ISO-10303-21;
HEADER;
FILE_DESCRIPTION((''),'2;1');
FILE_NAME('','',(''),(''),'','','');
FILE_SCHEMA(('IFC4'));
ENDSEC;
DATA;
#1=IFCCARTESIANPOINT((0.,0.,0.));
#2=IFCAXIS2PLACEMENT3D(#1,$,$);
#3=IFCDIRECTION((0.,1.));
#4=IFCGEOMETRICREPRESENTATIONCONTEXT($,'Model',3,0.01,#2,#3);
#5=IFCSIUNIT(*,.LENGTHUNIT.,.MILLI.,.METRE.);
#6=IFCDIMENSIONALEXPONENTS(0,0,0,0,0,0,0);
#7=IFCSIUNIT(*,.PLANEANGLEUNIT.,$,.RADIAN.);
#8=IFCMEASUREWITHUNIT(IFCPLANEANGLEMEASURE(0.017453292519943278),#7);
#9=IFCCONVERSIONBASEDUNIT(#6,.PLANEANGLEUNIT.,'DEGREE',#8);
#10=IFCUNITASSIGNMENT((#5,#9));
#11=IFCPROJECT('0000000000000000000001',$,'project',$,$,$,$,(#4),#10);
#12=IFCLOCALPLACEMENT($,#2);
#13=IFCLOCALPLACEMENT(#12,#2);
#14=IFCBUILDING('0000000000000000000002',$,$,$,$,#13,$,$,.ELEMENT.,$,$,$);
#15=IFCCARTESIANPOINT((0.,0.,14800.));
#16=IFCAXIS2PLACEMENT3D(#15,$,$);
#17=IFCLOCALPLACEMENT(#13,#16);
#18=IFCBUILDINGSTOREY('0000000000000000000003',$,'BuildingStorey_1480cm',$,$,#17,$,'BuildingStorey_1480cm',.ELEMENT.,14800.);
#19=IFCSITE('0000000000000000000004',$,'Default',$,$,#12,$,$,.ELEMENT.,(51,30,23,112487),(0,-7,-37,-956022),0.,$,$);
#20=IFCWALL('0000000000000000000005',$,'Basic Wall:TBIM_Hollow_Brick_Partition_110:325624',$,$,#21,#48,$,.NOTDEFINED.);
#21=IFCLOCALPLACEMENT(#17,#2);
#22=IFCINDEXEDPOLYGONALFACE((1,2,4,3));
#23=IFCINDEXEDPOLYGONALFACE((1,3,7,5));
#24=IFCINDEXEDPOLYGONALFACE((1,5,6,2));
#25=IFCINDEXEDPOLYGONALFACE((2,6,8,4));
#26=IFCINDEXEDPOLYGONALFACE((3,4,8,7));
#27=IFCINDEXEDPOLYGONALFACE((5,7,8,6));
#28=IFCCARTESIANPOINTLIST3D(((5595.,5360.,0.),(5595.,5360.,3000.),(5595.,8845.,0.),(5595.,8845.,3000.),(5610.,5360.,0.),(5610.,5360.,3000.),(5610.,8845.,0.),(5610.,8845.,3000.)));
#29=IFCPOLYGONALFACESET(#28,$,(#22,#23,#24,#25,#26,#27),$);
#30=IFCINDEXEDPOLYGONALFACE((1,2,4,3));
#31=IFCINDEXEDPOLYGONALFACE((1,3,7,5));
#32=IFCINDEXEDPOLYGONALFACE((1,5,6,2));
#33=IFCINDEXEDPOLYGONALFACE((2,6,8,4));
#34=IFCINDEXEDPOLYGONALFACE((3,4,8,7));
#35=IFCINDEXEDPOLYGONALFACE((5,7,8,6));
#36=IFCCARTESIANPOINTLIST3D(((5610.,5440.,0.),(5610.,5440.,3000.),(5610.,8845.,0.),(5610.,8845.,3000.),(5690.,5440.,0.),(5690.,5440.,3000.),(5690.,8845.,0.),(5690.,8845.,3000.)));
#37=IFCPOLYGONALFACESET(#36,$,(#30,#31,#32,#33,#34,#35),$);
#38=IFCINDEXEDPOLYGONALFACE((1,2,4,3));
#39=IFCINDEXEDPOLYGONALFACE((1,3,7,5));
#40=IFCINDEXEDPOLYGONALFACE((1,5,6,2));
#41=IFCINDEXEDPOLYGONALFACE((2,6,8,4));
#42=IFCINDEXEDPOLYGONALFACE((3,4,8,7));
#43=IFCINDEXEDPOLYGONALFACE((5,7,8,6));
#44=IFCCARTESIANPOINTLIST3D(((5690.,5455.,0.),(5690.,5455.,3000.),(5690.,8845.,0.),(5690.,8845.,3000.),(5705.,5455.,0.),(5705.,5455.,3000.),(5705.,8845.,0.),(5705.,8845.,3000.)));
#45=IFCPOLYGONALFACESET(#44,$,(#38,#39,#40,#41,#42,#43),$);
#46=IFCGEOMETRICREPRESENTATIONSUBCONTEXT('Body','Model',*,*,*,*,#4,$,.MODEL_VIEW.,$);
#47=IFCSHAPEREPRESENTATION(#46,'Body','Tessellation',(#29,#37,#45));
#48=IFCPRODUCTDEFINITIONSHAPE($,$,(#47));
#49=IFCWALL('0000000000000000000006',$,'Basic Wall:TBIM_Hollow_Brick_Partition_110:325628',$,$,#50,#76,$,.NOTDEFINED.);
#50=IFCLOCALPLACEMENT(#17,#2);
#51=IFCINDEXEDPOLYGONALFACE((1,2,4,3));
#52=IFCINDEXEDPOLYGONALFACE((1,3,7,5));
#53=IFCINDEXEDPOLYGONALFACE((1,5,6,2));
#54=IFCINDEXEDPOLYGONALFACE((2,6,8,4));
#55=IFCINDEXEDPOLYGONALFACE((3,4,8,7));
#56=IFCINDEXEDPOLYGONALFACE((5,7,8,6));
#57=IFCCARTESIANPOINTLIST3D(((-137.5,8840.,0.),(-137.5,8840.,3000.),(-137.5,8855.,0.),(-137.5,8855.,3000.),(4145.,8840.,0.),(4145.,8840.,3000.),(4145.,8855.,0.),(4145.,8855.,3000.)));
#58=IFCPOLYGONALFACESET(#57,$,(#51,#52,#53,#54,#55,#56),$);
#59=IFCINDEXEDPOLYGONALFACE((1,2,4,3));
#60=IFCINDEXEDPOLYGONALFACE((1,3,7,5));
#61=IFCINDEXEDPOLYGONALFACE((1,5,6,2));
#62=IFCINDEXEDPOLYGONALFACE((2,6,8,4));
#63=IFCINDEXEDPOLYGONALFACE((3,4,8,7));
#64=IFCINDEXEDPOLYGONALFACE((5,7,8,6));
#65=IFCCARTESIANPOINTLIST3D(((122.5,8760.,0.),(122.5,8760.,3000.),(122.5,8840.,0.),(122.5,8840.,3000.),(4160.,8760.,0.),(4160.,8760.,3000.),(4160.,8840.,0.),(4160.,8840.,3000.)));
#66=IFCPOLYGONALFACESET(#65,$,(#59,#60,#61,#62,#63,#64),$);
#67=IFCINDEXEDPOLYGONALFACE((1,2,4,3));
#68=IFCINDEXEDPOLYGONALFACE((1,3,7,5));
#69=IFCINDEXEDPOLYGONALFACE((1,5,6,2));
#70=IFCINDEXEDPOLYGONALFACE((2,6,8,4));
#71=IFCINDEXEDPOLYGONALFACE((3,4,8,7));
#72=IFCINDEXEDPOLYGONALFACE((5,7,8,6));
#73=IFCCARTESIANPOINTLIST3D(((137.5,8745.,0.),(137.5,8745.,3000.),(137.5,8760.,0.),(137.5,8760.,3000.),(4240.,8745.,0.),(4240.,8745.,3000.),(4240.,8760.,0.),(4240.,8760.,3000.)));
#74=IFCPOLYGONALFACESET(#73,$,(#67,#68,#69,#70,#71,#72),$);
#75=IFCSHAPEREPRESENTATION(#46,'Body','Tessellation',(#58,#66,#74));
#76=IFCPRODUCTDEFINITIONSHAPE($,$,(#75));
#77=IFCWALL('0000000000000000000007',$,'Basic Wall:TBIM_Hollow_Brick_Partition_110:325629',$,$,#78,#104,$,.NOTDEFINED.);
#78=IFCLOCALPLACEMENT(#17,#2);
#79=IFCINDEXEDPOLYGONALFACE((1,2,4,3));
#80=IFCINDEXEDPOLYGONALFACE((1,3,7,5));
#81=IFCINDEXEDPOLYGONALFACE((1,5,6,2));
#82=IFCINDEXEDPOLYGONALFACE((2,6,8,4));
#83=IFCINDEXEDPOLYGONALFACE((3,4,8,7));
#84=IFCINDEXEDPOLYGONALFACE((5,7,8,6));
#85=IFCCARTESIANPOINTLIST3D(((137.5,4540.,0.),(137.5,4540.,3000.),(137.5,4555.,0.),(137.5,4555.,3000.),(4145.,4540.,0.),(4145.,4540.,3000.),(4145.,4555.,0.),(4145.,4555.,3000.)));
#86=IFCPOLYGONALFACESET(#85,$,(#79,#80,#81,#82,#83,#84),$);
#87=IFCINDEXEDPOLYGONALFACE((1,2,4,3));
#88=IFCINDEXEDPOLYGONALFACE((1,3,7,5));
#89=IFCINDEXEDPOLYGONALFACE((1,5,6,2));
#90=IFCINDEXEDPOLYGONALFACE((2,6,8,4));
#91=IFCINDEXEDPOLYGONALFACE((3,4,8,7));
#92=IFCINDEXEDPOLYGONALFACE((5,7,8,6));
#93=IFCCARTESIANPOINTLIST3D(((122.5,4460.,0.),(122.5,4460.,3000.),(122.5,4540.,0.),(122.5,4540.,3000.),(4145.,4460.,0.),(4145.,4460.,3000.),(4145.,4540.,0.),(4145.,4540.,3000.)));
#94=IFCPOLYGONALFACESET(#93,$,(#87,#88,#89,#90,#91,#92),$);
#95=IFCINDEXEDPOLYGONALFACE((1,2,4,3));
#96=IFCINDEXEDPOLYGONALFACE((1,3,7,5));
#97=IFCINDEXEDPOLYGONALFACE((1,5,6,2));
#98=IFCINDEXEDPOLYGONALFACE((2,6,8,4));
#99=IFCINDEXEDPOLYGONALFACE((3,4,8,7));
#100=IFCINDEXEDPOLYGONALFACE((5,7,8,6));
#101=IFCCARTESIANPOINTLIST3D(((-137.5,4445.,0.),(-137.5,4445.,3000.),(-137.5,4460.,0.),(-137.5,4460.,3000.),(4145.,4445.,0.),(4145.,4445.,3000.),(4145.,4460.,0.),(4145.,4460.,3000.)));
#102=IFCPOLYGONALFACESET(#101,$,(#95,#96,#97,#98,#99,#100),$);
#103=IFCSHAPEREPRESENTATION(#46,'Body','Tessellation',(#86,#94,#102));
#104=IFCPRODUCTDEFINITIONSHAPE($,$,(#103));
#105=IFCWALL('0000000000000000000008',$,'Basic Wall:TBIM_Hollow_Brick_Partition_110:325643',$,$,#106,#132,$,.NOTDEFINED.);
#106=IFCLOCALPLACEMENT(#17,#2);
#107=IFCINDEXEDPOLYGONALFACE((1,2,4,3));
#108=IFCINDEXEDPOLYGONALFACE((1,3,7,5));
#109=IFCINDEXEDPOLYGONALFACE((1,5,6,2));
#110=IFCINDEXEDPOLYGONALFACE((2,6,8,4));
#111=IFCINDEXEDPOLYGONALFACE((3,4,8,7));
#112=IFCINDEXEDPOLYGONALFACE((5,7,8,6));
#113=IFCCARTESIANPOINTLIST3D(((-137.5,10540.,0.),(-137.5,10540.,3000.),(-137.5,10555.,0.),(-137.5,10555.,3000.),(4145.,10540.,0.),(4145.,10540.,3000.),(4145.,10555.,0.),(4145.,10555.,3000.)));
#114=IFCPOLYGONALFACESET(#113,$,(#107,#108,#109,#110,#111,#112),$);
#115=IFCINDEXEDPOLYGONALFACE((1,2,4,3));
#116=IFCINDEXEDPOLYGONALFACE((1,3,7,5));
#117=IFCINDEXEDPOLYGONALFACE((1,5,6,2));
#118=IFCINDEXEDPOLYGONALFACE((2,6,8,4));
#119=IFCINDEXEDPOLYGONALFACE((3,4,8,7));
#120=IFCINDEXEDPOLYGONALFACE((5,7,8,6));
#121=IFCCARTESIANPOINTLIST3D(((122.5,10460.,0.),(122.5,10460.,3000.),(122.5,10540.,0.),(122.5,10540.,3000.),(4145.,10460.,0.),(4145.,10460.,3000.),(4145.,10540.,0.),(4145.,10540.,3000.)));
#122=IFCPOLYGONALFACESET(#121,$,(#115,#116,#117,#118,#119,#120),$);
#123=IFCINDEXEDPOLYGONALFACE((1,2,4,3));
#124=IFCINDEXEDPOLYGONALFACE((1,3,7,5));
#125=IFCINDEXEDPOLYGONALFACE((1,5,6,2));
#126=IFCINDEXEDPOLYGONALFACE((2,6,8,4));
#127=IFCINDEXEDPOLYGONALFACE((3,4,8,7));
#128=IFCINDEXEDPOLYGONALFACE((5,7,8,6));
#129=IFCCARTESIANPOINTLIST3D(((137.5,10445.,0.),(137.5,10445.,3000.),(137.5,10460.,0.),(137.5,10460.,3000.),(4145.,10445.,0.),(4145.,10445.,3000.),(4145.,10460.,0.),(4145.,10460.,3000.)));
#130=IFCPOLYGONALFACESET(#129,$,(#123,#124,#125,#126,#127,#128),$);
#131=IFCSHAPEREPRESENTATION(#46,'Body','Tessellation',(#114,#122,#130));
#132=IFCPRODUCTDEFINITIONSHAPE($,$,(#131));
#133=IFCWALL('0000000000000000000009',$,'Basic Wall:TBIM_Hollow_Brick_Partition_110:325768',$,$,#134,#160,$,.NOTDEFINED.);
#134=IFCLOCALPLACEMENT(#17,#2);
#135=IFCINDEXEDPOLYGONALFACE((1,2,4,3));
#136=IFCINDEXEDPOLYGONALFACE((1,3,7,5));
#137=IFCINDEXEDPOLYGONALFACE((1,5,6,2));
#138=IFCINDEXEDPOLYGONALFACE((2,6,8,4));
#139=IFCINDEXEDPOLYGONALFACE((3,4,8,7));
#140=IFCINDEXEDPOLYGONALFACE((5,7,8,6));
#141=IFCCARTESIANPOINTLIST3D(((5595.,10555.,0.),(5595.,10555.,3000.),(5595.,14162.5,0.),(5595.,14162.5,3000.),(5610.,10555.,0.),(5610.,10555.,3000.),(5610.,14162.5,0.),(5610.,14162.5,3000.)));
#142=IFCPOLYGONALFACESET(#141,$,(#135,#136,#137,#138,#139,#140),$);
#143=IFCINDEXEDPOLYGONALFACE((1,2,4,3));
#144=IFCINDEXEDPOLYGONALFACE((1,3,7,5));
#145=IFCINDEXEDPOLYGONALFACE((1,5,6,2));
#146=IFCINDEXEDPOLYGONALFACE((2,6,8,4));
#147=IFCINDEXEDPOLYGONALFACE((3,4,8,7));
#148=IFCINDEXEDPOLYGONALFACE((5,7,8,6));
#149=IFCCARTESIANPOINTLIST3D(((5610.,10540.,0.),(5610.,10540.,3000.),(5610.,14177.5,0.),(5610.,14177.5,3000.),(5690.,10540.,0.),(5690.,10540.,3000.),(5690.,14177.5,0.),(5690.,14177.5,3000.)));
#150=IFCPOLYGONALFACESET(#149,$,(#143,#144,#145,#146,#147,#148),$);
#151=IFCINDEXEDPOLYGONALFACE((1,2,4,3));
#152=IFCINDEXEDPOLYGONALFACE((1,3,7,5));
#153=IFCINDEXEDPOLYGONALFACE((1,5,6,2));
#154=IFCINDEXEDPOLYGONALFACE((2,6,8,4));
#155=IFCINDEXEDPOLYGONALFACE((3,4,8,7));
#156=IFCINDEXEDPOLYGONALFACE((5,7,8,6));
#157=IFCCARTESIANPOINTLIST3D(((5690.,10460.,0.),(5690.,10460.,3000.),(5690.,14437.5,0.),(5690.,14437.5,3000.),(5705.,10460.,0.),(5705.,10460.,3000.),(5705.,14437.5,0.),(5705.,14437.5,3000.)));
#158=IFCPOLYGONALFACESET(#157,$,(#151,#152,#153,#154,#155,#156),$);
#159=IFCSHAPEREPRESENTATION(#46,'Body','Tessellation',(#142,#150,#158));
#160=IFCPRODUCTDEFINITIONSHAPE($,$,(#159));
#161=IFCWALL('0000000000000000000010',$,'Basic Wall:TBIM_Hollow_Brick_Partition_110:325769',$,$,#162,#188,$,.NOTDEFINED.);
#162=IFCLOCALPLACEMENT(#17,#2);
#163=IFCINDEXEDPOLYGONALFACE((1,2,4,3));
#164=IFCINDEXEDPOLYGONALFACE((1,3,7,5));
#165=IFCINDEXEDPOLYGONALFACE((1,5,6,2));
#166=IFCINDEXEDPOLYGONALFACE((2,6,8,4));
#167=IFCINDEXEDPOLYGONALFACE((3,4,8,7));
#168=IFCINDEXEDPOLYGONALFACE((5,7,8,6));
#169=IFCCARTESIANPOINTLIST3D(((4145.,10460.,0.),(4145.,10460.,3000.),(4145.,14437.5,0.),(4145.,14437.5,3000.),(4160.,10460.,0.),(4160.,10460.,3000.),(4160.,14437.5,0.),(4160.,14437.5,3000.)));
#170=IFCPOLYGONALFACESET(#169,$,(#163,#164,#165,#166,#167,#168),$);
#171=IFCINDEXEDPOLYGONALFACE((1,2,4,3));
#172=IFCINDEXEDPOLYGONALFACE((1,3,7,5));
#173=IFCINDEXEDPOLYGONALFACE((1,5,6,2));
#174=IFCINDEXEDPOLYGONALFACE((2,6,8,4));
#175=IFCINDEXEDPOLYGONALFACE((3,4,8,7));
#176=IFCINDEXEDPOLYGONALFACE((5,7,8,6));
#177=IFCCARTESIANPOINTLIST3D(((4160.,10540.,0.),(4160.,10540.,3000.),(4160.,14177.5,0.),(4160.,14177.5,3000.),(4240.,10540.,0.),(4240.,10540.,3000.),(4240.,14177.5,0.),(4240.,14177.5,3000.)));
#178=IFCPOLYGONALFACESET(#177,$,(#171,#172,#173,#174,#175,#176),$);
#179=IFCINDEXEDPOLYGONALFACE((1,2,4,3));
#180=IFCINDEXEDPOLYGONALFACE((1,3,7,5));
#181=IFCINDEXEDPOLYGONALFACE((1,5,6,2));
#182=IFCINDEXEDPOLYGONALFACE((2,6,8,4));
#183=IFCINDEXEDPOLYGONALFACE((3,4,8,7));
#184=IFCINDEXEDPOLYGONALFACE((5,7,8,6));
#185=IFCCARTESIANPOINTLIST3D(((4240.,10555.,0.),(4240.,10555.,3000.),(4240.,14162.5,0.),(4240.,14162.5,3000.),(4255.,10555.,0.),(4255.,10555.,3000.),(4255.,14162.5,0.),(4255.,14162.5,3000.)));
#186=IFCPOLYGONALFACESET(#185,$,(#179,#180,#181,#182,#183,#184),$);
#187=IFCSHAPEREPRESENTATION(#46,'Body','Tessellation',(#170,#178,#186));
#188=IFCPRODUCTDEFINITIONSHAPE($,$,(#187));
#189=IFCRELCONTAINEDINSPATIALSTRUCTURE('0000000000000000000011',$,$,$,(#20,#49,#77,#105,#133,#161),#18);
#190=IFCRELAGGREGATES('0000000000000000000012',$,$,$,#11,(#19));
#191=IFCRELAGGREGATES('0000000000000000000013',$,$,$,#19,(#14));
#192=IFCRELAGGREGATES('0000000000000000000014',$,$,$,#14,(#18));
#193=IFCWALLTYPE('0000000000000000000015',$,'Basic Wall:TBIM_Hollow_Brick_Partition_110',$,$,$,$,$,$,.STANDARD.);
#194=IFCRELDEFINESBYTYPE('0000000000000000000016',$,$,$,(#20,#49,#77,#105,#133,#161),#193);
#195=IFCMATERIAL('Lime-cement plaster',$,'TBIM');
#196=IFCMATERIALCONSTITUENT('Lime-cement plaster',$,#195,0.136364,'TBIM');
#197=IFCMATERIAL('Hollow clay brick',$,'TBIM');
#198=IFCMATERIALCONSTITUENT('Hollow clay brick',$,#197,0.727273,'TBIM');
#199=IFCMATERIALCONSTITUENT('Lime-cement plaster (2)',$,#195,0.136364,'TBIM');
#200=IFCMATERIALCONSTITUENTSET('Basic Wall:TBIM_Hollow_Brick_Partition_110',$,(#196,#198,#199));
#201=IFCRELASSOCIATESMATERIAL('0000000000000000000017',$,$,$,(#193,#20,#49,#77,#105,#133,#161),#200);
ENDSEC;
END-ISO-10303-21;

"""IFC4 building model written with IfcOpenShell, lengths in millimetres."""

from ifc_helpers import new_model, entity, si_unit, converted_unit, direction, frame, origin, place, context, subcontext, project, spatial, indexed_curve, outline, extrude, material, constituent, constituent_set, type_object, element, save


model = new_model("IFC4")

# Units and contexts
model_context = context("Model", 3, precision=0.01, world=origin(), true_north=direction((0.0, 1.0)))
body_context = subcontext(model_context, "Body", "Model", "MODEL_VIEW")
ifc_project = project(units=[si_unit("LENGTHUNIT", "METRE", prefix="MILLI"), converted_unit("PLANEANGLEUNIT", "DEGREE", entity("IfcPlaneAngleMeasure", 0.017453292519943278), si_unit("PLANEANGLEUNIT", "RADIAN"), dimensions=[0, 0, 0, 0, 0, 0, 0])], contexts=[model_context])

# Site, building, storey
site_placement = place(None, origin())
site = spatial("IfcSite", under=ifc_project, at=site_placement, Name="Default", CompositionType="ELEMENT", RefLatitude=(51, 30, 23, 112487), RefLongitude=(0, -7, -37, -956022), RefElevation=0.0)
building_placement = place(site_placement, origin())
building = spatial("IfcBuilding", under=site, at=building_placement, CompositionType="ELEMENT")
storey_placement = place(building_placement, frame((0.0, 0.0, 14800.0)))
storey = spatial("IfcBuildingStorey", under=building, at=storey_placement, Name="BuildingStorey_1480cm", LongName="BuildingStorey_1480cm", CompositionType="ELEMENT", Elevation=14800.0)

# Shared definitions
ifc_material_1 = material(Name="Lime-cement plaster", Category="TBIM")

# Shared definitions
ifc_material_2 = material(Name="Hollow clay brick", Category="TBIM")

# Shared definitions
ifc_constituent_1 = constituent(ifc_material_1, Name="Lime-cement plaster", Category="TBIM", fraction=0.136364)
ifc_constituent_2 = constituent(ifc_material_2, Name="Hollow clay brick", Category="TBIM", fraction=0.727273)
ifc_constituent_3 = constituent(ifc_material_1, Name="Lime-cement plaster (2)", Category="TBIM", fraction=0.136364)
ifc_constituent_set_1 = constituent_set(constituents=[ifc_constituent_1, ifc_constituent_2, ifc_constituent_3], Name="Basic Wall:TBIM_Hollow_Brick_Partition_110")
wall_type_1 = type_object("IfcWallType", Name="Basic Wall:TBIM_Hollow_Brick_Partition_110", PredefinedType="STANDARD", material=ifc_constituent_set_1)

# Wall
wall_1_placement = place(storey_placement, frame((5650.0, 5455.0, 0.0), z_axis=(0.0, 0.0, 1.0), x_axis=(0.0, 1.0, 0.0)))
element("IfcWall", 1, at=wall_1_placement, inside=storey, type_object=wall_type_1, material=ifc_constituent_set_1, Name="Basic Wall:TBIM_Hollow_Brick_Partition_110:325624", PredefinedType="NOTDEFINED", context=body_context, shape_type="SweptSolid", body=[
    extrude(outline(indexed_curve([(-7.5, -1742.5), (7.5, -1742.5), (7.5, 1742.5), (-7.5, 1742.5), (-7.5, -1742.5)], self_intersect=False)), frame((1647.5, 47.5, 0.0), z_axis=(0.0, 0.0, 1.0), x_axis=(0.0, -1.0, 0.0)), (0.0, 0.0, 1.0), 3000.0),
    extrude(outline(indexed_curve([(-1702.5, -40.0), (1702.5, -40.0), (1702.5, 40.0), (-1702.5, 40.0), (-1702.5, -40.0)], self_intersect=False)), frame((1687.5, 0.0, 0.0)), (0.0, 0.0, 1.0), 3000.0),
    extrude(outline(indexed_curve([(-7.5, -1695.0), (7.5, -1695.0), (7.5, 1695.0), (-7.5, 1695.0), (-7.5, -1695.0)], self_intersect=False)), frame((1695.0, -47.5, 0.0), z_axis=(0.0, 0.0, 1.0), x_axis=(0.0, 1.0, 0.0)), (0.0, 0.0, 1.0), 3000.0),
])

# Walls
wall_2_placement = place(storey_placement, frame((137.5, 8800.0, 0.0)))
element("IfcWall", 2, at=wall_2_placement, inside=storey, type_object=wall_type_1, material=ifc_constituent_set_1, Name="Basic Wall:TBIM_Hollow_Brick_Partition_110:325628", PredefinedType="NOTDEFINED", context=body_context, shape_type="SweptSolid", body=[
    extrude(outline(indexed_curve([(-7.5, -2141.2), (7.5, -2141.2), (7.5, 2141.2), (-7.5, 2141.2), (-7.5, -2141.2)], self_intersect=False)), frame((1866.2, 47.5, 0.0), z_axis=(0.0, 0.0, 1.0), x_axis=(0.0, -1.0, 0.0)), (0.0, 0.0, 1.0), 3000.0),
    extrude(outline(indexed_curve([(-2018.7, -40.0), (2018.7, -40.0), (2018.7, 40.0), (-2018.7, 40.0), (-2018.7, -40.0)], self_intersect=False)), frame((2003.7, 0.0, 0.0)), (0.0, 0.0, 1.0), 3000.0),
    extrude(outline(indexed_curve([(-7.5, -2051.2), (7.5, -2051.2), (7.5, 2051.2), (-7.5, 2051.2), (-7.5, -2051.2)], self_intersect=False)), frame((2051.2, -47.5, 0.0), z_axis=(0.0, 0.0, 1.0), x_axis=(0.0, 1.0, 0.0)), (0.0, 0.0, 1.0), 3000.0),
])
wall_3_placement = place(storey_placement, frame((137.5, 4500.0, 0.0)))
element("IfcWall", 3, at=wall_3_placement, inside=storey, type_object=wall_type_1, material=ifc_constituent_set_1, Name="Basic Wall:TBIM_Hollow_Brick_Partition_110:325629", PredefinedType="NOTDEFINED", context=body_context, shape_type="SweptSolid", body=[
    extrude(outline(indexed_curve([(-7.5, -2003.7), (7.5, -2003.7), (7.5, 2003.7), (-7.5, 2003.7), (-7.5, -2003.7)], self_intersect=False)), frame((2003.7, 47.5, 0.0), z_axis=(0.0, 0.0, 1.0), x_axis=(0.0, -1.0, 0.0)), (0.0, 0.0, 1.0), 3000.0),
    extrude(outline(indexed_curve([(-2011.2, -40.0), (2011.2, -40.0), (2011.2, 40.0), (-2011.2, 40.0), (-2011.2, -40.0)], self_intersect=False)), frame((1996.2, 0.0, 0.0)), (0.0, 0.0, 1.0), 3000.0),
    extrude(outline(indexed_curve([(-7.5, -2141.2), (7.5, -2141.2), (7.5, 2141.2), (-7.5, 2141.2), (-7.5, -2141.2)], self_intersect=False)), frame((1866.2, -47.5, 0.0), z_axis=(0.0, 0.0, 1.0), x_axis=(0.0, 1.0, 0.0)), (0.0, 0.0, 1.0), 3000.0),
])
wall_4_placement = place(storey_placement, frame((137.5, 10500.0, 0.0)))
element("IfcWall", 4, at=wall_4_placement, inside=storey, type_object=wall_type_1, material=ifc_constituent_set_1, Name="Basic Wall:TBIM_Hollow_Brick_Partition_110:325643", PredefinedType="NOTDEFINED", context=body_context, shape_type="SweptSolid", body=[
    extrude(outline(indexed_curve([(-7.5, -2141.2), (7.5, -2141.2), (7.5, 2141.2), (-7.5, 2141.2), (-7.5, -2141.2)], self_intersect=False)), frame((1866.2, 47.5, 0.0), z_axis=(0.0, 0.0, 1.0), x_axis=(0.0, -1.0, 0.0)), (0.0, 0.0, 1.0), 3000.0),
    extrude(outline(indexed_curve([(-2011.2, -40.0), (2011.2, -40.0), (2011.2, 40.0), (-2011.2, 40.0), (-2011.2, -40.0)], self_intersect=False)), frame((1996.2, 0.0, 0.0)), (0.0, 0.0, 1.0), 3000.0),
    extrude(outline(indexed_curve([(-7.5, -2003.7), (7.5, -2003.7), (7.5, 2003.7), (-7.5, 2003.7), (-7.5, -2003.7)], self_intersect=False)), frame((2003.7, -47.5, 0.0), z_axis=(0.0, 0.0, 1.0), x_axis=(0.0, 1.0, 0.0)), (0.0, 0.0, 1.0), 3000.0),
])
wall_5_placement = place(storey_placement, frame((5650.0, 10555.0, 0.0), z_axis=(0.0, 0.0, 1.0), x_axis=(0.0, 1.0, 0.0)))
element("IfcWall", 5, at=wall_5_placement, inside=storey, type_object=wall_type_1, material=ifc_constituent_set_1, Name="Basic Wall:TBIM_Hollow_Brick_Partition_110:325768", PredefinedType="NOTDEFINED", context=body_context, shape_type="SweptSolid", body=[
    extrude(outline(indexed_curve([(-7.5, -1803.7), (7.5, -1803.7), (7.5, 1803.8), (-7.5, 1803.8), (-7.5, -1803.7)], self_intersect=False)), frame((1803.7, 47.5, 0.0), z_axis=(0.0, 0.0, 1.0), x_axis=(0.0, -1.0, 0.0)), (0.0, 0.0, 1.0), 3000.0),
    extrude(outline(indexed_curve([(-1818.8, -40.0), (1818.8, -40.0), (1818.8, 40.0), (-1818.8, 40.0), (-1818.8, -40.0)], self_intersect=False)), frame((1803.7, 0.0, 0.0)), (0.0, 0.0, 1.0), 3000.0),
    extrude(outline(indexed_curve([(-7.5, -1988.8), (7.5, -1988.8), (7.5, 1988.8), (-7.5, 1988.8), (-7.5, -1988.8)], self_intersect=False)), frame((1893.8, -47.5, 0.0), z_axis=(0.0, 0.0, 1.0), x_axis=(0.0, 1.0, 0.0)), (0.0, 0.0, 1.0), 3000.0),
])
wall_6_placement = place(storey_placement, frame((4200.0, 10555.0, 0.0), z_axis=(0.0, 0.0, 1.0), x_axis=(0.0, 1.0, 0.0)))
element("IfcWall", 6, at=wall_6_placement, inside=storey, type_object=wall_type_1, material=ifc_constituent_set_1, Name="Basic Wall:TBIM_Hollow_Brick_Partition_110:325769", PredefinedType="NOTDEFINED", context=body_context, shape_type="SweptSolid", body=[
    extrude(outline(indexed_curve([(-7.5, -1988.8), (7.5, -1988.8), (7.5, 1988.8), (-7.5, 1988.8), (-7.5, -1988.8)], self_intersect=False)), frame((1893.8, 47.5, 0.0), z_axis=(0.0, 0.0, 1.0), x_axis=(0.0, -1.0, 0.0)), (0.0, 0.0, 1.0), 3000.0),
    extrude(outline(indexed_curve([(-1818.8, -40.0), (1818.8, -40.0), (1818.8, 40.0), (-1818.8, 40.0), (-1818.8, -40.0)], self_intersect=False)), frame((1803.7, 0.0, 0.0)), (0.0, 0.0, 1.0), 3000.0),
    extrude(outline(indexed_curve([(-7.5, -1803.8), (7.5, -1803.8), (7.5, 1803.7), (-7.5, 1803.7), (-7.5, -1803.8)], self_intersect=False)), frame((1803.7, -47.5, 0.0), z_axis=(0.0, 0.0, 1.0), x_axis=(0.0, 1.0, 0.0)), (0.0, 0.0, 1.0), 3000.0),
])

save(model, "model.ifc")
